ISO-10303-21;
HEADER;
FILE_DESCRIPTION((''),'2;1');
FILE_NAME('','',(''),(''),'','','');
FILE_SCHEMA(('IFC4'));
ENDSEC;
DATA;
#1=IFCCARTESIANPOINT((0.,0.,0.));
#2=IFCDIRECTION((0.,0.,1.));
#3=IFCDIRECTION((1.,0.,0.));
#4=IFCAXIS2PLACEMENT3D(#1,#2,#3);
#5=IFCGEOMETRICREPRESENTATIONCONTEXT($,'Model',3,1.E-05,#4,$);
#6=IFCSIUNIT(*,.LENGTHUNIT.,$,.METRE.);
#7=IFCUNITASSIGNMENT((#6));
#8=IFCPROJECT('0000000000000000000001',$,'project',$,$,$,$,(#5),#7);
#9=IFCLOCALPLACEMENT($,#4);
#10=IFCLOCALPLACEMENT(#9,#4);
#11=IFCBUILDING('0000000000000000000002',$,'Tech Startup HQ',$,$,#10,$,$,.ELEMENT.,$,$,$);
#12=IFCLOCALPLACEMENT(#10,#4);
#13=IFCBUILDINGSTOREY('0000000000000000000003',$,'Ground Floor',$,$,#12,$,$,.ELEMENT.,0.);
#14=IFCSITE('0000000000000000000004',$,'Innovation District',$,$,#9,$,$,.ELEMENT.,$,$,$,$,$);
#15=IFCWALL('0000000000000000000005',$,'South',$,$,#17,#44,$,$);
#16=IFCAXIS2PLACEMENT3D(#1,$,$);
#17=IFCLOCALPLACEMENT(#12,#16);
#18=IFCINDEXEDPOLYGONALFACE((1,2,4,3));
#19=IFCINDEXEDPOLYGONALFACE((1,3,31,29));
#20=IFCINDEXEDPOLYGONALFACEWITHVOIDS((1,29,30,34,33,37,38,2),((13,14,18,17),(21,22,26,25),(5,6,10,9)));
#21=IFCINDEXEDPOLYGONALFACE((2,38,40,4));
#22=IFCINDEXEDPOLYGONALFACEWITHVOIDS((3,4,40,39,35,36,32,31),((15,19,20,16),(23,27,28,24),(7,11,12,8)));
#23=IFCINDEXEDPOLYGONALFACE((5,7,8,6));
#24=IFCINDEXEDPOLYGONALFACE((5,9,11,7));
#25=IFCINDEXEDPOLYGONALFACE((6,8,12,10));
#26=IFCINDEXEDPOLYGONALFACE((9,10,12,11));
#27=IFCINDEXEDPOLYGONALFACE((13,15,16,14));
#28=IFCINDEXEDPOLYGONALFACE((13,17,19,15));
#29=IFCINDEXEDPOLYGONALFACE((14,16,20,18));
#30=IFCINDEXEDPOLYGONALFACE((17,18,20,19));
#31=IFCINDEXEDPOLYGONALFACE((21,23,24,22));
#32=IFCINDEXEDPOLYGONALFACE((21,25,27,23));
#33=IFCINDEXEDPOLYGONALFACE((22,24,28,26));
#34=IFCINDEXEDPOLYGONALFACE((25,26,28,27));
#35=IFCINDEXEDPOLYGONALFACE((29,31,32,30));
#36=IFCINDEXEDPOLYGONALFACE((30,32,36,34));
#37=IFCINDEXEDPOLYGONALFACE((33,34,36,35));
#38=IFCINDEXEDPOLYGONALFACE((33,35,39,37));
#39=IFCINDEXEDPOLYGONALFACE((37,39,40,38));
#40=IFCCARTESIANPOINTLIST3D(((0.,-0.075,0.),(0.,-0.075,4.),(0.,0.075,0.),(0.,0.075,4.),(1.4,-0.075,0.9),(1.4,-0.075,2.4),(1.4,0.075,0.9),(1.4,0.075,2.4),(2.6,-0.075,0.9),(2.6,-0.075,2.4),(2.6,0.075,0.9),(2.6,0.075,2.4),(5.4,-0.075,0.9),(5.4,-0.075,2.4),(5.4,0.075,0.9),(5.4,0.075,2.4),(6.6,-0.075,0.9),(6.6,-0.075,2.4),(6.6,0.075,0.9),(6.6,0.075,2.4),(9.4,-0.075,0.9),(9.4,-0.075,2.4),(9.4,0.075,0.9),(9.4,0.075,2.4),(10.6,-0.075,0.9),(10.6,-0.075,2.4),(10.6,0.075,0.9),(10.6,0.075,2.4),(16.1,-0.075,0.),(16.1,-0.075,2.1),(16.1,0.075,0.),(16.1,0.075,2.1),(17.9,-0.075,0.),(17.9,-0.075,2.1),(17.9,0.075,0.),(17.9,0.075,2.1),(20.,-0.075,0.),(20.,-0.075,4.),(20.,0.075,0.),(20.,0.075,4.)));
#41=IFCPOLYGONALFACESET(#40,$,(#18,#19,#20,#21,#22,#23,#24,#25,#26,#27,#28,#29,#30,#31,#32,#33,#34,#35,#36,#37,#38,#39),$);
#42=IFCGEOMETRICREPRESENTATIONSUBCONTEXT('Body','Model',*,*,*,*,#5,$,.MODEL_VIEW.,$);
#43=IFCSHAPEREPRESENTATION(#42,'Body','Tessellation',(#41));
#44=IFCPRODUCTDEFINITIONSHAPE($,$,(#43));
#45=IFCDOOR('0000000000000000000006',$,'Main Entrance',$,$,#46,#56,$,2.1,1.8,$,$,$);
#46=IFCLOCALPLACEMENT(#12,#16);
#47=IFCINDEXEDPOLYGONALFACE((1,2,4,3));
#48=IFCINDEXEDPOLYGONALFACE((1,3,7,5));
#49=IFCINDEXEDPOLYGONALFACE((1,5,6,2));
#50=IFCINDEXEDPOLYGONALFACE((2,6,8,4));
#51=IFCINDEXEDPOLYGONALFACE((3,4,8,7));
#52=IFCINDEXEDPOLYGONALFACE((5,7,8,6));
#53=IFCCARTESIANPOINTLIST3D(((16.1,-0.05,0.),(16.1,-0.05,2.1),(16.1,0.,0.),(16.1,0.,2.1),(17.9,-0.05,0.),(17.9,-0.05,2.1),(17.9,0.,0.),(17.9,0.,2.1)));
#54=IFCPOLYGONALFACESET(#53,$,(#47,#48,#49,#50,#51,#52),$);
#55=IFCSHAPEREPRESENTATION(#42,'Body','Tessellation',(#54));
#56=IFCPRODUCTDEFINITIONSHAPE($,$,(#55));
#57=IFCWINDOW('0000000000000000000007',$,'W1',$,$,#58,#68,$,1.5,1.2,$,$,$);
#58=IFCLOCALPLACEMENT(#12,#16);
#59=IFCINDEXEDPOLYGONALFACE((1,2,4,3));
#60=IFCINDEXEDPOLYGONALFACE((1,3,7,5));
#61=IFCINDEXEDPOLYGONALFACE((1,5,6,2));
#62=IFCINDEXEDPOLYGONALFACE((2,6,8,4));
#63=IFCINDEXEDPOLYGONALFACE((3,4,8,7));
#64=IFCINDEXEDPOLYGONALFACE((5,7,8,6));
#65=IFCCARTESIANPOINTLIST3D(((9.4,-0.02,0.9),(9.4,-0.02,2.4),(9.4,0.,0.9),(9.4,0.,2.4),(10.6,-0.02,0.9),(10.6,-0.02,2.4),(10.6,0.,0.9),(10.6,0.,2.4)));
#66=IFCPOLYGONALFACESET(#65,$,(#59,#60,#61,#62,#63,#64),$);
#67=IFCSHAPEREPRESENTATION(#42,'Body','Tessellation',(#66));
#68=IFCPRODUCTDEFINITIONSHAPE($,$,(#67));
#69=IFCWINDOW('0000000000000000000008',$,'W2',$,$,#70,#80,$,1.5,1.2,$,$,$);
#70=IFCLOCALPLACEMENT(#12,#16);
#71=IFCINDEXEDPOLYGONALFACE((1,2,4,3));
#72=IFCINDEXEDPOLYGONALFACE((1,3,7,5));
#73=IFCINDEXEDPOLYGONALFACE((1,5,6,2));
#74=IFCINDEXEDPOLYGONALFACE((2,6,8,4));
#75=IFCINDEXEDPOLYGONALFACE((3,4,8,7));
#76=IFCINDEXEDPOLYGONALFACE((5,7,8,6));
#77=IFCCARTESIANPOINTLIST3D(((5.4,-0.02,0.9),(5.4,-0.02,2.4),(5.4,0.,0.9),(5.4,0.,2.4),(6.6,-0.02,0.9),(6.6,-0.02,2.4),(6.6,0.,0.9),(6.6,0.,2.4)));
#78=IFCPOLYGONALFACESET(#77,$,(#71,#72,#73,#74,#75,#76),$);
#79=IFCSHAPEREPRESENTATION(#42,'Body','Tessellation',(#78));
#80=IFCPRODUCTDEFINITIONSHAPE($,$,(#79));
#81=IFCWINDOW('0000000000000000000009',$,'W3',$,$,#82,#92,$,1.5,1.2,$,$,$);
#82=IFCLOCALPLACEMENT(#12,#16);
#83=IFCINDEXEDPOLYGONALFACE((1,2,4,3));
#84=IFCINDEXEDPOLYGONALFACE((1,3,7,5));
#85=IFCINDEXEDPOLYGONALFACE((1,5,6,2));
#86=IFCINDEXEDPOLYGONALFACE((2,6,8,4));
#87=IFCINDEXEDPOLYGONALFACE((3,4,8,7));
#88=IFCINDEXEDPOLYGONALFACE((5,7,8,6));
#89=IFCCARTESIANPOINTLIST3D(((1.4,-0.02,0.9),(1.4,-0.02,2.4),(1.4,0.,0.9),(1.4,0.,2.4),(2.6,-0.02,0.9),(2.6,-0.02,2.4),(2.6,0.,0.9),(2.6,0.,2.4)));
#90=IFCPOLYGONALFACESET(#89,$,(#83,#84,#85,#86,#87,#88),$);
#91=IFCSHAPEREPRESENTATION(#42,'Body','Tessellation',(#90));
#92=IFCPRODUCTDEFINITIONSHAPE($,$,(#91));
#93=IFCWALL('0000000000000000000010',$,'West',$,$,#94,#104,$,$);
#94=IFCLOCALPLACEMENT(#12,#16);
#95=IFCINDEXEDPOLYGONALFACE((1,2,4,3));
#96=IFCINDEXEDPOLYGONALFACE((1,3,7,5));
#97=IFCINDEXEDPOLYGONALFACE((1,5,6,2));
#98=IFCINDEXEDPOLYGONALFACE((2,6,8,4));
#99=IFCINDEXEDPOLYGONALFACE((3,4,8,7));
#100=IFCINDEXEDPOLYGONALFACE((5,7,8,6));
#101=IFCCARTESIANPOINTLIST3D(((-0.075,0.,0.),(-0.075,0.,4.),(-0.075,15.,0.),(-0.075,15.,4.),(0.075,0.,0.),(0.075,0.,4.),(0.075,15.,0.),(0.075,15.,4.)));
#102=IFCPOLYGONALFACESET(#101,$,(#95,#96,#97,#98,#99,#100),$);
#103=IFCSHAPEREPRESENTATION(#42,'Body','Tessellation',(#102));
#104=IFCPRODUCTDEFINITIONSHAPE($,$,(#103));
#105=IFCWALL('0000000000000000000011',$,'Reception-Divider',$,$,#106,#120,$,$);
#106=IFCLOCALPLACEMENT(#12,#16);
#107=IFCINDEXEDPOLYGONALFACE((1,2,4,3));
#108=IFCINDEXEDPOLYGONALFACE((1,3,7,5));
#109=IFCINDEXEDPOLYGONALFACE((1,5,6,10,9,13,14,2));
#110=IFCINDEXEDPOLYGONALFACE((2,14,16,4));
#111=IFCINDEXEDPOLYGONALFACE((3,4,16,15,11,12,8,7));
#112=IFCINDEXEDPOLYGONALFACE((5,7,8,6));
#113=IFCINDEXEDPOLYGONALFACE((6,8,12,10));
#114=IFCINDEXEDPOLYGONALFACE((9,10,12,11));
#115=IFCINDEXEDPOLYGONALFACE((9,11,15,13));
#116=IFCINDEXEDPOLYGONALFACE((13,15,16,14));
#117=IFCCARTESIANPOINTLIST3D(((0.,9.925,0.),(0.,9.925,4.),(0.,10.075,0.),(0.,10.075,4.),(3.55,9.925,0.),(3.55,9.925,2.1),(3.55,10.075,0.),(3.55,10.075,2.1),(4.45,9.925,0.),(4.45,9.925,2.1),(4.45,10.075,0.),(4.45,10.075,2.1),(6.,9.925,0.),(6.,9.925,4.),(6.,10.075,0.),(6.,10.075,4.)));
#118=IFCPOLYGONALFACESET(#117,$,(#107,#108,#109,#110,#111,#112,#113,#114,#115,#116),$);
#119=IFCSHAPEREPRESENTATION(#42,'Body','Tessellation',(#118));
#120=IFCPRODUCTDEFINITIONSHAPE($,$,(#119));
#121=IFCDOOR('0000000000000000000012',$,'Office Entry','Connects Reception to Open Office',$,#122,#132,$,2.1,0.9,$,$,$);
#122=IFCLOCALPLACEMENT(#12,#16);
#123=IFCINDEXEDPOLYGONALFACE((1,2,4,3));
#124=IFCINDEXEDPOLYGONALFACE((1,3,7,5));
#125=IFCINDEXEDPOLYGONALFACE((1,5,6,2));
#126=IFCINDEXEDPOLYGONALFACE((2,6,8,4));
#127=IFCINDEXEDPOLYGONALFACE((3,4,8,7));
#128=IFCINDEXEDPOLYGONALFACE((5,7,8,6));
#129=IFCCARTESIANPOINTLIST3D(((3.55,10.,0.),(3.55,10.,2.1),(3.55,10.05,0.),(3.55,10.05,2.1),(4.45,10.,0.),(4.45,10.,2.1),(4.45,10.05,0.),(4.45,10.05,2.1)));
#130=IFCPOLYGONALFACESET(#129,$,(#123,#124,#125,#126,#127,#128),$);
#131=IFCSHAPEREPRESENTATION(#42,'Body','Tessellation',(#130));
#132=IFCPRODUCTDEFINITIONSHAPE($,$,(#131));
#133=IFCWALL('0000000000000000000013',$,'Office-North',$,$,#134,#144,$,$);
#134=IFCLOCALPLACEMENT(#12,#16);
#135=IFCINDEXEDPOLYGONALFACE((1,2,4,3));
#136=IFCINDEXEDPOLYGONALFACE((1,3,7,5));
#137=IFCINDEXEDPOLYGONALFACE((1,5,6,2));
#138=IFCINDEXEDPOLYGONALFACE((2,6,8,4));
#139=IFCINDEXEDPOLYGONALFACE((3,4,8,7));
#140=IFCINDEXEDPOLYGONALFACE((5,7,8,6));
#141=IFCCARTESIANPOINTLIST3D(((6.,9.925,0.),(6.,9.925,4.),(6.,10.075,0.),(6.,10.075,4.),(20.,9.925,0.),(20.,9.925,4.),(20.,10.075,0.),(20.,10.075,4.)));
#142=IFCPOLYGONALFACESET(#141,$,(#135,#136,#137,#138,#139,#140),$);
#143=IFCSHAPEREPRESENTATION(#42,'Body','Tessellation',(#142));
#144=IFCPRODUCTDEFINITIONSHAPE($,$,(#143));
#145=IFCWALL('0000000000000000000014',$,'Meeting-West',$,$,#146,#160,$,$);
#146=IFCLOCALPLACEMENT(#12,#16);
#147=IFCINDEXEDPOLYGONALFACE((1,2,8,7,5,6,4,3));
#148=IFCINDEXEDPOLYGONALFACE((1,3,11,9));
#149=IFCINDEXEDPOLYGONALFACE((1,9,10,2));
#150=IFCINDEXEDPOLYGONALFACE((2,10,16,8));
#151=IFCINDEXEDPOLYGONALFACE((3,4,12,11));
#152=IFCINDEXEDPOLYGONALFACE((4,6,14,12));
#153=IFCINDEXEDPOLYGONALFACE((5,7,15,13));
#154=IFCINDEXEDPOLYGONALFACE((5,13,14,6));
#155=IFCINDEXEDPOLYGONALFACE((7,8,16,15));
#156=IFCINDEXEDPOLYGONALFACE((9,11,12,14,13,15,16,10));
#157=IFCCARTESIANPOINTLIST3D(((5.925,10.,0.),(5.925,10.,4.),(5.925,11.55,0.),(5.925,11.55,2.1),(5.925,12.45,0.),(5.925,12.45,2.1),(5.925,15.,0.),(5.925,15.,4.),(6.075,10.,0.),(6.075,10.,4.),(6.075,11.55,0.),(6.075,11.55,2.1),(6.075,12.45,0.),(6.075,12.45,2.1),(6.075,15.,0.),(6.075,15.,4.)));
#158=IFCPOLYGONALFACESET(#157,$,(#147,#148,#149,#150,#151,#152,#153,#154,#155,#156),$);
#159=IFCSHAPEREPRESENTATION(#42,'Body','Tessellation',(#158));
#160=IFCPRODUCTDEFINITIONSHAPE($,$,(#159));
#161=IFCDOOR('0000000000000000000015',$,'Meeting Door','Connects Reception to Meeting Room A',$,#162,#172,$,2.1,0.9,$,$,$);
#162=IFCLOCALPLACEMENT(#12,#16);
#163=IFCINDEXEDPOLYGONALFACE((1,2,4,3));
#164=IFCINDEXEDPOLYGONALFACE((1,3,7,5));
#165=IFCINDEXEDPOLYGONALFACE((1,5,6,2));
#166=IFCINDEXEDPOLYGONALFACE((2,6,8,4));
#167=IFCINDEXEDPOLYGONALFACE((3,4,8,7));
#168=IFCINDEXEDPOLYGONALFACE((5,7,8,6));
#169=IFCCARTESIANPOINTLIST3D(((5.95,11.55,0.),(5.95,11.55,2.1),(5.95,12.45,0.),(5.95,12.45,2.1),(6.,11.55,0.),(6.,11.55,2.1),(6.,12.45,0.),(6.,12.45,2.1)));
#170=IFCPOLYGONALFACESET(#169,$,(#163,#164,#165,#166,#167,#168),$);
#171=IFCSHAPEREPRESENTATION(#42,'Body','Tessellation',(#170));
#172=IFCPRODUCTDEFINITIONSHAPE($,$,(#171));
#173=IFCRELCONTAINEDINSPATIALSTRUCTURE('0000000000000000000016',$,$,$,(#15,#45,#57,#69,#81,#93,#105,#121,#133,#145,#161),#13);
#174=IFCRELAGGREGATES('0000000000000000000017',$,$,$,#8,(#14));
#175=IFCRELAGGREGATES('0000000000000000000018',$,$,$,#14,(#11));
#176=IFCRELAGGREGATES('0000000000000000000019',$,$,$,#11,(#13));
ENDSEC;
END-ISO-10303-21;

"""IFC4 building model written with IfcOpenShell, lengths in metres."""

from ifc_helpers import new_model, si_unit, origin_with_axes, place, context, subcontext, project, spatial, polyline, outline, extrude, element, fill, save


model = new_model("IFC4")

# Units and contexts
model_context = context("Model", 3, precision=1e-05, world=origin_with_axes())
body_context = subcontext(model_context, "Body", "Model", "MODEL_VIEW")
ifc_project = project(units=[si_unit("LENGTHUNIT", "METRE")], contexts=[model_context])

# Site, building, storey
site_placement = place(None, origin_with_axes())
site = spatial("IfcSite", under=ifc_project, at=site_placement, Name="Innovation District", CompositionType="ELEMENT")
building_placement = place(site_placement, origin_with_axes())
building = spatial("IfcBuilding", under=site, at=building_placement, Name="Tech Startup HQ", CompositionType="ELEMENT")
storey_placement = place(building_placement, origin_with_axes())
storey = spatial("IfcBuildingStorey", under=building, at=storey_placement, Name="Ground Floor", CompositionType="ELEMENT", Elevation=0.0)

# Wall, openings, door, windows
wall_1_placement = place(storey_placement, origin_with_axes())
wall_1 = element("IfcWall", 1, at=wall_1_placement, inside=storey, Name="South", context=body_context, shape_type="SweptSolid", body=[
    extrude(outline(polyline([(20.0, 0.075, 0.0), (0.0, 0.075, 0.0), (0.0, -0.075, 0.0), (20.0, -0.075, 0.0), (20.0, 0.075, 0.0)])), None, (0.0, 0.0, 1.0), 4.0),
])
opening_1_placement = place(storey_placement, origin_with_axes())
opening_1 = element("IfcOpeningElement", 2, at=opening_1_placement, inside=storey, cuts=wall_1, context=body_context, shape_type="SweptSolid", body=[
    extrude(outline(polyline([(17.9, 0.15, 0.0), (16.1, 0.15, 0.0), (16.1, -0.15, 0.0), (17.9, -0.15, 0.0), (17.9, 0.15, 0.0)])), None, (0.0, 0.0, 1.0), 2.1),
])
opening_2_placement = place(storey_placement, origin_with_axes())
opening_2 = element("IfcOpeningElement", 3, at=opening_2_placement, inside=storey, cuts=wall_1, context=body_context, shape_type="SweptSolid", body=[
    extrude(outline(polyline([(10.6, 0.15, 0.9), (9.4, 0.15, 0.9), (9.4, -0.15, 0.9), (10.6, -0.15, 0.9), (10.6, 0.15, 0.9)])), None, (0.0, 0.0, 1.0), 1.5),
])
opening_3_placement = place(storey_placement, origin_with_axes())
opening_3 = element("IfcOpeningElement", 4, at=opening_3_placement, inside=storey, cuts=wall_1, context=body_context, shape_type="SweptSolid", body=[
    extrude(outline(polyline([(6.6, 0.15, 0.9), (5.4, 0.15, 0.9), (5.4, -0.15, 0.9), (6.6, -0.15, 0.9), (6.6, 0.15, 0.9)])), None, (0.0, 0.0, 1.0), 1.5),
])
opening_4_placement = place(storey_placement, origin_with_axes())
opening_4 = element("IfcOpeningElement", 5, at=opening_4_placement, inside=storey, cuts=wall_1, context=body_context, shape_type="SweptSolid", body=[
    extrude(outline(polyline([(2.6, 0.15, 0.9), (1.4, 0.15, 0.9), (1.4, -0.15, 0.9), (2.6, -0.15, 0.9), (2.6, 0.15, 0.9)])), None, (0.0, 0.0, 1.0), 1.5),
])
door_1_placement = place(storey_placement, origin_with_axes())
door_1 = element("IfcDoor", 6, at=door_1_placement, inside=storey, Name="Main Entrance", OverallHeight=2.1, OverallWidth=1.8, context=body_context, shape_type="SweptSolid", body=[
    extrude(outline(polyline([(17.9, 0.0, 0.0), (16.1, 0.0, 0.0), (16.1, -0.05, 0.0), (17.9, -0.05, 0.0), (17.9, 0.0, 0.0)])), None, (0.0, 0.0, 1.0), 2.1),
])
fill(opening_1, door_1)
window_1_placement = place(storey_placement, origin_with_axes())
window_1 = element("IfcWindow", 7, at=window_1_placement, inside=storey, Name="W1", OverallHeight=1.5, OverallWidth=1.2, context=body_context, shape_type="SweptSolid", body=[
    extrude(outline(polyline([(10.6, 0.0, 0.9), (9.4, 0.0, 0.9), (9.4, -0.02, 0.9), (10.6, -0.02, 0.9), (10.6, 0.0, 0.9)])), None, (0.0, 0.0, 1.0), 1.5),
])
fill(opening_2, window_1)
window_2_placement = place(storey_placement, origin_with_axes())
window_2 = element("IfcWindow", 8, at=window_2_placement, inside=storey, Name="W2", OverallHeight=1.5, OverallWidth=1.2, context=body_context, shape_type="SweptSolid", body=[
    extrude(outline(polyline([(6.6, 0.0, 0.9), (5.4, 0.0, 0.9), (5.4, -0.02, 0.9), (6.6, -0.02, 0.9), (6.6, 0.0, 0.9)])), None, (0.0, 0.0, 1.0), 1.5),
])
fill(opening_3, window_2)
window_3_placement = place(storey_placement, origin_with_axes())
window_3 = element("IfcWindow", 9, at=window_3_placement, inside=storey, Name="W3", OverallHeight=1.5, OverallWidth=1.2, context=body_context, shape_type="SweptSolid", body=[
    extrude(outline(polyline([(2.6, 0.0, 0.9), (1.4, 0.0, 0.9), (1.4, -0.02, 0.9), (2.6, -0.02, 0.9), (2.6, 0.0, 0.9)])), None, (0.0, 0.0, 1.0), 1.5),
])
fill(opening_4, window_3)

# Wall
wall_2_placement = place(storey_placement, origin_with_axes())
element("IfcWall", 10, at=wall_2_placement, inside=storey, Name="West", context=body_context, shape_type="SweptSolid", body=[
    extrude(outline(polyline([(0.075, 0.0, 0.0), (0.075, 15.0, 0.0), (-0.075, 15.0, 0.0), (-0.075, 0.0, 0.0), (0.075, 0.0, 0.0)])), None, (0.0, 0.0, 1.0), 4.0),
])

# Wall, opening, door
wall_3_placement = place(storey_placement, origin_with_axes())
wall_3 = element("IfcWall", 11, at=wall_3_placement, inside=storey, Name="Reception-Divider", context=body_context, shape_type="SweptSolid", body=[
    extrude(outline(polyline([(0.0, 9.925, 0.0), (6.0, 9.925, 0.0), (6.0, 10.075, 0.0), (0.0, 10.075, 0.0), (0.0, 9.925, 0.0)])), None, (0.0, 0.0, 1.0), 4.0),
])
opening_5_placement = place(storey_placement, origin_with_axes())
opening_5 = element("IfcOpeningElement", 12, at=opening_5_placement, inside=storey, cuts=wall_3, context=body_context, shape_type="SweptSolid", body=[
    extrude(outline(polyline([(3.55, 9.85, 0.0), (4.45, 9.85, 0.0), (4.45, 10.15, 0.0), (3.55, 10.15, 0.0), (3.55, 9.85, 0.0)])), None, (0.0, 0.0, 1.0), 2.1),
])
door_2_placement = place(storey_placement, origin_with_axes())
door_2 = element("IfcDoor", 13, at=door_2_placement, inside=storey, Name="Office Entry", Description="Connects Reception to Open Office", OverallHeight=2.1, OverallWidth=0.9, context=body_context, shape_type="SweptSolid", body=[
    extrude(outline(polyline([(3.55, 10.0, 0.0), (4.45, 10.0, 0.0), (4.45, 10.05, 0.0), (3.55, 10.05, 0.0), (3.55, 10.0, 0.0)])), None, (0.0, 0.0, 1.0), 2.1),
])
fill(opening_5, door_2)

# Wall
wall_4_placement = place(storey_placement, origin_with_axes())
element("IfcWall", 14, at=wall_4_placement, inside=storey, Name="Office-North", context=body_context, shape_type="SweptSolid", body=[
    extrude(outline(polyline([(6.0, 9.925, 0.0), (20.0, 9.925, 0.0), (20.0, 10.075, 0.0), (6.0, 10.075, 0.0), (6.0, 9.925, 0.0)])), None, (0.0, 0.0, 1.0), 4.0),
])

# Wall, opening, door
wall_5_placement = place(storey_placement, origin_with_axes())
wall_5 = element("IfcWall", 15, at=wall_5_placement, inside=storey, Name="Meeting-West", context=body_context, shape_type="SweptSolid", body=[
    extrude(outline(polyline([(6.075, 10.0, 0.0), (6.075, 15.0, 0.0), (5.925, 15.0, 0.0), (5.925, 10.0, 0.0), (6.075, 10.0, 0.0)])), None, (0.0, 0.0, 1.0), 4.0),
])
opening_6_placement = place(storey_placement, origin_with_axes())
opening_6 = element("IfcOpeningElement", 16, at=opening_6_placement, inside=storey, cuts=wall_5, context=body_context, shape_type="SweptSolid", body=[
    extrude(outline(polyline([(6.15, 11.55, 0.0), (6.15, 12.45, 0.0), (5.85, 12.45, 0.0), (5.85, 11.55, 0.0), (6.15, 11.55, 0.0)])), None, (0.0, 0.0, 1.0), 2.1),
])
door_3_placement = place(storey_placement, origin_with_axes())
door_3 = element("IfcDoor", 17, at=door_3_placement, inside=storey, Name="Meeting Door", Description="Connects Reception to Meeting Room A", OverallHeight=2.1, OverallWidth=0.9, context=body_context, shape_type="SweptSolid", body=[
    extrude(outline(polyline([(6.0, 11.55, 0.0), (6.0, 12.45, 0.0), (5.95, 12.45, 0.0), (5.95, 11.55, 0.0), (6.0, 11.55, 0.0)])), None, (0.0, 0.0, 1.0), 2.1),
])
fill(opening_6, door_3)

save(model, "model.ifc")
